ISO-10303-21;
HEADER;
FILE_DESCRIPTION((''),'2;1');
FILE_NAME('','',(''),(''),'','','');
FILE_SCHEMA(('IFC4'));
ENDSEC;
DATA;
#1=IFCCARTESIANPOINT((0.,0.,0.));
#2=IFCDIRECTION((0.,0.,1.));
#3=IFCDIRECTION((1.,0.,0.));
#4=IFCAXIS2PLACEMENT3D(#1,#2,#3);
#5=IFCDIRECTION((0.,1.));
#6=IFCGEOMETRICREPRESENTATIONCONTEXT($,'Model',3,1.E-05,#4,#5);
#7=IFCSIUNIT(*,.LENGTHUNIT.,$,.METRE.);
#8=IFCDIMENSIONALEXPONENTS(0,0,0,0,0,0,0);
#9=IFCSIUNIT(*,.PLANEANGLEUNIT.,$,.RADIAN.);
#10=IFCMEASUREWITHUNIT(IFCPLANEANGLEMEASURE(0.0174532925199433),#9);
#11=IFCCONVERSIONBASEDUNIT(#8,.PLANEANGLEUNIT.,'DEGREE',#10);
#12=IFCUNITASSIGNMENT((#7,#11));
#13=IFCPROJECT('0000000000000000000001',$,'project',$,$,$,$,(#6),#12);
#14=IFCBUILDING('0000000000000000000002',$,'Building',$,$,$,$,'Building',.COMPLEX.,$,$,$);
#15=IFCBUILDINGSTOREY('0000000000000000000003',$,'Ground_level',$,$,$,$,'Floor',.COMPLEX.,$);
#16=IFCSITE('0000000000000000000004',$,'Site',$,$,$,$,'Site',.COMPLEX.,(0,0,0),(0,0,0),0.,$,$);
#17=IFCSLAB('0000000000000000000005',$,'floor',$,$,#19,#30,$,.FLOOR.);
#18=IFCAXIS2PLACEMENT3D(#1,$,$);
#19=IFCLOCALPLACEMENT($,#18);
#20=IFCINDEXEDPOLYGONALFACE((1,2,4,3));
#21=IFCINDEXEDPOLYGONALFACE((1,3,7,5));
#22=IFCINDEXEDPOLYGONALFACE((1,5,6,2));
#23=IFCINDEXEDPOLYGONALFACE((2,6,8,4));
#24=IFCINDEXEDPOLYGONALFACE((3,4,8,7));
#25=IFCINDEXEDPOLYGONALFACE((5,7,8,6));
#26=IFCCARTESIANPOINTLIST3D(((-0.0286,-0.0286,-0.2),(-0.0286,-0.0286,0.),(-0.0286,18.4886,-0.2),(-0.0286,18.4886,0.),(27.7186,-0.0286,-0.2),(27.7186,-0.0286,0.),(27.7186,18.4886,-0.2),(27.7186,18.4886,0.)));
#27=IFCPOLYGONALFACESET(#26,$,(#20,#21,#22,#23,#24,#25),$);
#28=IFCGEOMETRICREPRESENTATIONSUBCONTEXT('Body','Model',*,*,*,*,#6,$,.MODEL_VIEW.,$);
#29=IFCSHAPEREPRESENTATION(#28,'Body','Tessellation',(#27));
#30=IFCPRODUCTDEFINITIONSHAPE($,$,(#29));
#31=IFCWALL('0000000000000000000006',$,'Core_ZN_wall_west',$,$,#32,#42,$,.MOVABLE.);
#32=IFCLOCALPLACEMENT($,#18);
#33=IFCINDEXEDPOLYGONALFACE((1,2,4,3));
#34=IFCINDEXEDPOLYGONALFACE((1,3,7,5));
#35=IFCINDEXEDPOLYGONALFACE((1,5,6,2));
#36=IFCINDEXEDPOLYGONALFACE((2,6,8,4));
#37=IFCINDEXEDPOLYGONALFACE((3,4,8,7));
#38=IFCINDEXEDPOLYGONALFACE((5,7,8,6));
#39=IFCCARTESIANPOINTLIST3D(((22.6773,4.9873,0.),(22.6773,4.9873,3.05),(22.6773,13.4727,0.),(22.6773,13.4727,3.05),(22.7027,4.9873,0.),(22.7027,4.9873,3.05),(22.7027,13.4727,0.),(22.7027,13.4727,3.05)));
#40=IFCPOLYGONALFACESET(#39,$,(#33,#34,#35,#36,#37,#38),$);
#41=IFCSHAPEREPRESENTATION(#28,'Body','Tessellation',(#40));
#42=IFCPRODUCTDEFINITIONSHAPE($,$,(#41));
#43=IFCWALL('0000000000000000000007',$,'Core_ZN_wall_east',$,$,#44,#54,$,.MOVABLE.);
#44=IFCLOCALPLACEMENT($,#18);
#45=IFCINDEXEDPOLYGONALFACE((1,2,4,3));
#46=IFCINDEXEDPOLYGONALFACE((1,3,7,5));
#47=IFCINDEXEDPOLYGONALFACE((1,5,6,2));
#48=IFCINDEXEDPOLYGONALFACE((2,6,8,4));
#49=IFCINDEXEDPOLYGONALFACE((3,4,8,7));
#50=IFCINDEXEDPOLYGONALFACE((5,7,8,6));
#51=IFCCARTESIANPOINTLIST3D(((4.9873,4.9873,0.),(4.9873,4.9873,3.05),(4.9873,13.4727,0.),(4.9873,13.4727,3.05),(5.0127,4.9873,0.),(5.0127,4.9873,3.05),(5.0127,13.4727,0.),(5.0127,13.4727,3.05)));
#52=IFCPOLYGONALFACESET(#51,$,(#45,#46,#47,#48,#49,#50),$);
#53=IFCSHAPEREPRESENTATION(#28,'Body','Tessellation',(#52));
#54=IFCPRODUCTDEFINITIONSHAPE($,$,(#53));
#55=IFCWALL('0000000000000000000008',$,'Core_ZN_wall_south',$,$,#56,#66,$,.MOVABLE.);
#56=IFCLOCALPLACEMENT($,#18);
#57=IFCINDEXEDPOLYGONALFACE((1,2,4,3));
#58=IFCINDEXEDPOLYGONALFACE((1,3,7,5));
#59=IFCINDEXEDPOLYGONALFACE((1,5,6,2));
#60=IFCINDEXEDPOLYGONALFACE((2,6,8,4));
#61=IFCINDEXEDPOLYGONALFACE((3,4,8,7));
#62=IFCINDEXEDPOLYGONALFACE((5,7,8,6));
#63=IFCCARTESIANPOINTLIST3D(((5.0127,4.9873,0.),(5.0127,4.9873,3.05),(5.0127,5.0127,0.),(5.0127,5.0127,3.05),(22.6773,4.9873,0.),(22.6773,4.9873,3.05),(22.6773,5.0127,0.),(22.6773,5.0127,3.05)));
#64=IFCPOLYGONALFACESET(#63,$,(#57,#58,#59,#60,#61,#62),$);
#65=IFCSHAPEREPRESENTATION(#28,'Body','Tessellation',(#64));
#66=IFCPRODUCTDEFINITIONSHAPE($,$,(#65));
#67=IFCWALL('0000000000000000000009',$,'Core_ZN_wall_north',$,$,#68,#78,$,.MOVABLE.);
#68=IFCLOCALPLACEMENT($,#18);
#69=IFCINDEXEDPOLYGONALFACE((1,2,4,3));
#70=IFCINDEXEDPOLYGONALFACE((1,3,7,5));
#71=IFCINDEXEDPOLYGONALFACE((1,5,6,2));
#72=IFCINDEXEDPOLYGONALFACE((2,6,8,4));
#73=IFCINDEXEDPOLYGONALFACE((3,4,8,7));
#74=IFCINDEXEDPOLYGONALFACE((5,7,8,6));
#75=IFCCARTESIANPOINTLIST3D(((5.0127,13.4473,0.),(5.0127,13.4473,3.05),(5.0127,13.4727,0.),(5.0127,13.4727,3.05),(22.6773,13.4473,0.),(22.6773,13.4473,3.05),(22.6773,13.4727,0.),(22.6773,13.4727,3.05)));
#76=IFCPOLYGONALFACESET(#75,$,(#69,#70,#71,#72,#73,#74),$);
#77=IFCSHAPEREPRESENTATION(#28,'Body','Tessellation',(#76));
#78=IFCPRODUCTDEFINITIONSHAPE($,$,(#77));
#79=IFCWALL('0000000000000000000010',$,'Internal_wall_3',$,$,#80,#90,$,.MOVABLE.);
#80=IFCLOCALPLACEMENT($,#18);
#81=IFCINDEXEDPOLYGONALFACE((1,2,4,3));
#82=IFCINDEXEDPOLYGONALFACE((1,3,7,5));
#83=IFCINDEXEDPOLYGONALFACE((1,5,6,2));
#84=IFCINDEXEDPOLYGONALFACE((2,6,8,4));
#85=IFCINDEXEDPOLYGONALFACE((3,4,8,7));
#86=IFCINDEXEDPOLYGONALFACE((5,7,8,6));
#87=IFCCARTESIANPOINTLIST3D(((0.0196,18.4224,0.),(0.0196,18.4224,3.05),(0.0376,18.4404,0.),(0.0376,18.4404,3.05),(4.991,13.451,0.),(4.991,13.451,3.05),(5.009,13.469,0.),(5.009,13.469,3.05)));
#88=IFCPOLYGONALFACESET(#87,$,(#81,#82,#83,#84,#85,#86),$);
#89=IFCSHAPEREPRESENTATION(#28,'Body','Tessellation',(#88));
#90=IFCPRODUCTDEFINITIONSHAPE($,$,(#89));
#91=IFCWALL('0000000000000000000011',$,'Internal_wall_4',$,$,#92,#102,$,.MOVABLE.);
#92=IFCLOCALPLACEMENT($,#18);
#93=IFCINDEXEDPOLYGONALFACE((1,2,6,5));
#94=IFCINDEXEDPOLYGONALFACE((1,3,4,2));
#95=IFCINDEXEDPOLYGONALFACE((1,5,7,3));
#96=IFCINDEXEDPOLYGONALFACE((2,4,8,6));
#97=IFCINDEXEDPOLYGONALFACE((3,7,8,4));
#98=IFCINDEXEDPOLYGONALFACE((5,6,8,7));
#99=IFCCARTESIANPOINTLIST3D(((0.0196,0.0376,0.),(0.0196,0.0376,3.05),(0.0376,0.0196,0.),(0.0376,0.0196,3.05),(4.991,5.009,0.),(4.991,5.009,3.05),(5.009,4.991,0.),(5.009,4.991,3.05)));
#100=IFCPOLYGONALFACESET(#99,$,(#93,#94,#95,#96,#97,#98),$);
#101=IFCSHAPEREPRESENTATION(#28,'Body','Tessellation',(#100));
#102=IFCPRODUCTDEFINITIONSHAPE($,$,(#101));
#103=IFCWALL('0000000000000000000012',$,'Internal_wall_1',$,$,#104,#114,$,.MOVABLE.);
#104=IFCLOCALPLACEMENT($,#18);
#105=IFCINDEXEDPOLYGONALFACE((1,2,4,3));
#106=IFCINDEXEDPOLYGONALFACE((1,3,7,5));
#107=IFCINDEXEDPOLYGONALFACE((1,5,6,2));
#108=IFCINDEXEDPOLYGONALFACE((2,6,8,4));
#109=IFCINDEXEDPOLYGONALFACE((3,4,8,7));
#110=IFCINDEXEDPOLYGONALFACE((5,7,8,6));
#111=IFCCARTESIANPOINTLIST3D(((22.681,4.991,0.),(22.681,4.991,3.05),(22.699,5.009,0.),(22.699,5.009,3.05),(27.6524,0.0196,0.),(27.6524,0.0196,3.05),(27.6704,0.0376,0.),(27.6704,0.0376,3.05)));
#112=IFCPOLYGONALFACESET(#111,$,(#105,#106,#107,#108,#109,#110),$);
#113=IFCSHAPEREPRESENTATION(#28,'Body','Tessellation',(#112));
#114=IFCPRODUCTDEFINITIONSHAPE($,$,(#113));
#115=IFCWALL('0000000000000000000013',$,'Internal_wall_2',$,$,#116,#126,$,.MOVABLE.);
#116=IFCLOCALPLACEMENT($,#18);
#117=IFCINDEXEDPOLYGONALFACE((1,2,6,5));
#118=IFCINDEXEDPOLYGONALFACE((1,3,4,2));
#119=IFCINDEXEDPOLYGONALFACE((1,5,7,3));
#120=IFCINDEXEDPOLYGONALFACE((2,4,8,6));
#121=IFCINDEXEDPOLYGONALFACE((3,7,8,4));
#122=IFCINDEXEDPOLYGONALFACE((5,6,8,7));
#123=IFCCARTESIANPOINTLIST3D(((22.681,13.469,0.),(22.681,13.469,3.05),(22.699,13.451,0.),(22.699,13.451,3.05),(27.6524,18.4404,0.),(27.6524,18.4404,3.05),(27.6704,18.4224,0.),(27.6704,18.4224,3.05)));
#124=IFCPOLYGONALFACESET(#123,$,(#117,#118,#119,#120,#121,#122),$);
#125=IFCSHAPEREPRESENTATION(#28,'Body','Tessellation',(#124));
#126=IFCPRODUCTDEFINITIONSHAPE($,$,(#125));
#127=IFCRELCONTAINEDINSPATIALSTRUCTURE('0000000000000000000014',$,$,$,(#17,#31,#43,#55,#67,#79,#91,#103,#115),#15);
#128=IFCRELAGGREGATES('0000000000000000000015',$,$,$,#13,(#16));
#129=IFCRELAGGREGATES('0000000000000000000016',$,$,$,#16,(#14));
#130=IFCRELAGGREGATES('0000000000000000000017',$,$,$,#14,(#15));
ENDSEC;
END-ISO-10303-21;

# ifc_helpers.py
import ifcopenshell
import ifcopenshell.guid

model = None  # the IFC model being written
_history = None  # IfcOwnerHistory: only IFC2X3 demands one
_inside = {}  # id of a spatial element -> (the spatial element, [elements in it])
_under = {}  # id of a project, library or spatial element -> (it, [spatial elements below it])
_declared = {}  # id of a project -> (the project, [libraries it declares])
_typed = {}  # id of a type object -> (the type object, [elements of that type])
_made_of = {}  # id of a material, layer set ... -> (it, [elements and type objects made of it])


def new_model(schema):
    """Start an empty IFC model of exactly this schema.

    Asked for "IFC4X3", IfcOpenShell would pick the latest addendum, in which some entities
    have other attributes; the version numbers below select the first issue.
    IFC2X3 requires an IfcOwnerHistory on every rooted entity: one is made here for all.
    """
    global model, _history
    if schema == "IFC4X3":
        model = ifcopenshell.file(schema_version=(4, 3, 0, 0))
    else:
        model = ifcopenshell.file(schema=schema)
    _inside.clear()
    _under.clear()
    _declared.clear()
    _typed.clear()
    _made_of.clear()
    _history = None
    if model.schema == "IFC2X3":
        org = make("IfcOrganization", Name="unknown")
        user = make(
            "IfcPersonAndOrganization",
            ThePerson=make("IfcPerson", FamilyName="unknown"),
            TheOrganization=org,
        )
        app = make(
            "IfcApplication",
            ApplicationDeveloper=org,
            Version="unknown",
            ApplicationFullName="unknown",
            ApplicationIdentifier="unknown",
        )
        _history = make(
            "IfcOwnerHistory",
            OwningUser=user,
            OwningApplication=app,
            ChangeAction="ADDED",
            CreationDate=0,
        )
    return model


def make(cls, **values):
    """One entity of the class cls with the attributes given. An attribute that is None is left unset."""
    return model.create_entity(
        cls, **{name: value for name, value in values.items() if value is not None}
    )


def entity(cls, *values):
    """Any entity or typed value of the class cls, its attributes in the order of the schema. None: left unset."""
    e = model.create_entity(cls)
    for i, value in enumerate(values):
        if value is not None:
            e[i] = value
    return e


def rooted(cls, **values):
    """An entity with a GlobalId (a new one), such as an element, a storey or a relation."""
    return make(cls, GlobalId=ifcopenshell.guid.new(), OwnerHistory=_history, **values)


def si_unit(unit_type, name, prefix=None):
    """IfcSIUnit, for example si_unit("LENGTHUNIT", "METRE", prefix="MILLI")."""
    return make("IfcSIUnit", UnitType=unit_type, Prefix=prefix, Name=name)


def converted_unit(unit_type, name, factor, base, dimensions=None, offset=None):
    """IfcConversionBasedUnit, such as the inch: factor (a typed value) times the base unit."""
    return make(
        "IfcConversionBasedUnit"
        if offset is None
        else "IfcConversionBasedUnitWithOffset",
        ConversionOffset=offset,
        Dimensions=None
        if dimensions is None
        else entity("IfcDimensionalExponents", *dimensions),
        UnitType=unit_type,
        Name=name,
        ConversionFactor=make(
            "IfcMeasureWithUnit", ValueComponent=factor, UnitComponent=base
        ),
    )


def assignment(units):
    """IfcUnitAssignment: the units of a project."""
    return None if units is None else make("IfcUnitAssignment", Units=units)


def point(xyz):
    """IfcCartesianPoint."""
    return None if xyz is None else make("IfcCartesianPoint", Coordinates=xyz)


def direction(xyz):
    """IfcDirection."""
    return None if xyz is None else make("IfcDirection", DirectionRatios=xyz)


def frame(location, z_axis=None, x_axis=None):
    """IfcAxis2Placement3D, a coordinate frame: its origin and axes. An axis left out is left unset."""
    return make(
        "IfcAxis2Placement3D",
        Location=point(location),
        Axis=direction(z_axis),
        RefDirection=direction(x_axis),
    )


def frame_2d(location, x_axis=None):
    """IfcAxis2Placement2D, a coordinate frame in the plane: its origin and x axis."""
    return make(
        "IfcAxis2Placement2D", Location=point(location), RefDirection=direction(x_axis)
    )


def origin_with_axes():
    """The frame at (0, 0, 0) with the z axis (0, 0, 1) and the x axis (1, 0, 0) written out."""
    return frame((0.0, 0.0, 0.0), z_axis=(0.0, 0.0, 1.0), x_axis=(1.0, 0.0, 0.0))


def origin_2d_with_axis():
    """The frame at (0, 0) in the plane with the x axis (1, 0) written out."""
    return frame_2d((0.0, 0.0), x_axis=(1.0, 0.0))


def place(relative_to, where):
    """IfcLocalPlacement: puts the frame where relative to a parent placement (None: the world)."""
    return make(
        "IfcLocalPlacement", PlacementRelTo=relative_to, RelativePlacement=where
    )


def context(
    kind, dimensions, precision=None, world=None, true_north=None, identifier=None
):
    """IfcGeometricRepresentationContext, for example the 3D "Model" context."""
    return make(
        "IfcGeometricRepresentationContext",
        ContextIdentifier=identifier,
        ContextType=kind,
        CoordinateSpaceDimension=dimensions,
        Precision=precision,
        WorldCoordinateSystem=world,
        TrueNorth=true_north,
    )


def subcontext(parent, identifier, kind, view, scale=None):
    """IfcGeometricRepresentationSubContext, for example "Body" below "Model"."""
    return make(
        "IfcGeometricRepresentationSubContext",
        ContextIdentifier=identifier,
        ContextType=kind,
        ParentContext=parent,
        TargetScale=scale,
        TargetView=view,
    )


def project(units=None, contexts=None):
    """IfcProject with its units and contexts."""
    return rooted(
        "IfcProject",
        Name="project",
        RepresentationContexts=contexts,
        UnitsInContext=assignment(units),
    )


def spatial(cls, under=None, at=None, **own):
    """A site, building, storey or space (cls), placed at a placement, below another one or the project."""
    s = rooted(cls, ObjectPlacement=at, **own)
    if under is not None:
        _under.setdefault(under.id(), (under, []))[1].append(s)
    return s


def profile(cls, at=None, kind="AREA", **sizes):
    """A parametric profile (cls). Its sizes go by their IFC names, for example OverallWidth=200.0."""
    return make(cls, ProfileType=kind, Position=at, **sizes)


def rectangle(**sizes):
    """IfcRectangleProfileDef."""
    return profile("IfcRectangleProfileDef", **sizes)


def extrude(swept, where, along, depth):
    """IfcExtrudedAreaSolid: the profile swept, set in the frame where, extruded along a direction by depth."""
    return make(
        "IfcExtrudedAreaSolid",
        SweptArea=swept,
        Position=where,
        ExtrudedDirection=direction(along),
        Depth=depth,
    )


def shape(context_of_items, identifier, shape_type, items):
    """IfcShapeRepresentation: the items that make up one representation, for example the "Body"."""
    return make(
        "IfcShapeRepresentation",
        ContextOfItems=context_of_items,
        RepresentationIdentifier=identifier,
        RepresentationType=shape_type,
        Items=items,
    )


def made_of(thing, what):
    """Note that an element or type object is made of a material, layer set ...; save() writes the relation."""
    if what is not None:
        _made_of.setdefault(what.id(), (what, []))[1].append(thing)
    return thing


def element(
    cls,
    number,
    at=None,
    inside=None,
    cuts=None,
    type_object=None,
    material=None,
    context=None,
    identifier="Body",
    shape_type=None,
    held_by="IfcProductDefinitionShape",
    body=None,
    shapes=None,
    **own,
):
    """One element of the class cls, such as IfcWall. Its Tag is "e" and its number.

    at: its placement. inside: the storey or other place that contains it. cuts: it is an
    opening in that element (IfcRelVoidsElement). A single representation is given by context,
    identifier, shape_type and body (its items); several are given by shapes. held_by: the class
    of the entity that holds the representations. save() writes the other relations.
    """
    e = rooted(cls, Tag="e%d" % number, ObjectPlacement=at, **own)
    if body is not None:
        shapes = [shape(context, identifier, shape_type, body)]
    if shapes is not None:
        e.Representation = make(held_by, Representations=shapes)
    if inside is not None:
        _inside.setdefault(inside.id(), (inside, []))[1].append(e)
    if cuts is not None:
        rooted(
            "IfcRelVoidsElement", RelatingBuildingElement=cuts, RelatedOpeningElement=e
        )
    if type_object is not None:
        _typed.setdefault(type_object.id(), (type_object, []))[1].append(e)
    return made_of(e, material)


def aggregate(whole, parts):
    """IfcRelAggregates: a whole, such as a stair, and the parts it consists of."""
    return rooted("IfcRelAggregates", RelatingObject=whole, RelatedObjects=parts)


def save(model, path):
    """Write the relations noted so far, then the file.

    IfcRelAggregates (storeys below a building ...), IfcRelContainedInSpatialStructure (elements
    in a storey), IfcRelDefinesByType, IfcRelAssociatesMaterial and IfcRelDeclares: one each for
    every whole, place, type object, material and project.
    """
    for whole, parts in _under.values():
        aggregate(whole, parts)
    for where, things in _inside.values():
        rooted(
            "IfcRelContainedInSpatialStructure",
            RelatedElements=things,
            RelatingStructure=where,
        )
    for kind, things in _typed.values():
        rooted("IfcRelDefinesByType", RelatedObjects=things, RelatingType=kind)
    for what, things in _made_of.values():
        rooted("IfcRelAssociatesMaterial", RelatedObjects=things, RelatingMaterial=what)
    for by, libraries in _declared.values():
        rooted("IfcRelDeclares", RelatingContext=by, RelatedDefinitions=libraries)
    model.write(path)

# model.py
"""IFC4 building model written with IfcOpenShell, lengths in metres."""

from ifc_helpers import new_model, entity, si_unit, converted_unit, direction, frame, frame_2d, origin_with_axes, origin_2d_with_axis, place, context, subcontext, project, spatial, rectangle, extrude, element, save


model = new_model("IFC4")

# Units and contexts
model_context = context("Model", 3, precision=1e-05, world=origin_with_axes(), true_north=direction((0.0, 1.0)))
body_context = subcontext(model_context, "Body", "Model", "MODEL_VIEW")
ifc_project = project(units=[si_unit("LENGTHUNIT", "METRE"), converted_unit("PLANEANGLEUNIT", "DEGREE", entity("IfcPlaneAngleMeasure", 0.0174532925199433), si_unit("PLANEANGLEUNIT", "RADIAN"), dimensions=[0, 0, 0, 0, 0, 0, 0])], contexts=[model_context])

# Site, building, storey
site = spatial("IfcSite", under=ifc_project, Name="Site", LongName="Site", CompositionType="COMPLEX", RefLatitude=(0, 0, 0), RefLongitude=(0, 0, 0), RefElevation=0.0)
building = spatial("IfcBuilding", under=site, Name="Building", LongName="Building", CompositionType="COMPLEX")
storey = spatial("IfcBuildingStorey", under=building, Name="Ground_level", LongName="Floor", CompositionType="COMPLEX")

# Slab
placement = place(None, origin_with_axes())
element("IfcSlab", 1, at=placement, inside=storey, Name="floor", PredefinedType="FLOOR", context=body_context, shape_type="SweptSolid", body=[
    extrude(rectangle(XDim=27.7472, YDim=18.5172, at=frame_2d((0.0, 0.0), x_axis=(-1.0, 0.0))), frame((13.845, 9.23, 0.0), z_axis=(0.0, 0.0, 1.0), x_axis=(1.0, 0.0, 0.0)), (0.0, 0.0, -1.0), 0.2),
])

# Walls
element("IfcWall", 2, at=placement, inside=storey, Name="Core_ZN_wall_west", PredefinedType="MOVABLE", context=body_context, shape_type="SweptSolid", body=[
    extrude(rectangle(XDim=8.4854, YDim=0.0254, at=frame_2d((0.0, 0.0), x_axis=(0.0, 1.0))), frame((22.69, 9.23, 0.0), z_axis=(0.0, 0.0, 1.0), x_axis=(1.0, 0.0, 0.0)), (0.0, 0.0, 1.0), 3.05),
])
element("IfcWall", 3, at=placement, inside=storey, Name="Core_ZN_wall_east", PredefinedType="MOVABLE", context=body_context, shape_type="SweptSolid", body=[
    extrude(rectangle(XDim=8.4854, YDim=0.0254, at=frame_2d((0.0, 0.0), x_axis=(0.0, 1.0))), frame((5.0, 9.23, 0.0), z_axis=(0.0, 0.0, 1.0), x_axis=(1.0, 0.0, 0.0)), (0.0, 0.0, 1.0), 3.05),
])
element("IfcWall", 4, at=placement, inside=storey, Name="Core_ZN_wall_south", PredefinedType="MOVABLE", context=body_context, shape_type="SweptSolid", body=[
    extrude(rectangle(XDim=17.6646, YDim=0.0254, at=origin_2d_with_axis()), frame((13.845, 5.0, 0.0), z_axis=(0.0, 0.0, 1.0), x_axis=(1.0, 0.0, 0.0)), (0.0, 0.0, 1.0), 3.05),
])
element("IfcWall", 5, at=placement, inside=storey, Name="Core_ZN_wall_north", PredefinedType="MOVABLE", context=body_context, shape_type="SweptSolid", body=[
    extrude(rectangle(XDim=17.6646, YDim=0.0254, at=frame_2d((0.0, 0.0), x_axis=(1.0, 0.0))), frame((13.845, 13.46, 0.0), z_axis=(0.0, 0.0, 1.0), x_axis=(1.0, 0.0, 0.0)), (0.0, 0.0, 1.0), 3.05),
])
element("IfcWall", 6, at=placement, inside=storey, Name="Internal_wall_3", PredefinedType="MOVABLE", context=body_context, shape_type="SweptSolid", body=[
    extrude(rectangle(XDim=7.0306, YDim=0.0254, at=frame_2d((0.0, 0.0), x_axis=(0.707107, -0.707107))), frame((2.5143, 15.9457, 0.0), z_axis=(0.0, 0.0, 1.0), x_axis=(1.0, 0.0, 0.0)), (0.0, 0.0, 1.0), 3.05),
])
element("IfcWall", 7, at=placement, inside=storey, Name="Internal_wall_4", PredefinedType="MOVABLE", context=body_context, shape_type="SweptSolid", body=[
    extrude(rectangle(XDim=7.0306, YDim=0.0254, at=frame_2d((0.0, 0.0), x_axis=(0.707107, 0.707107))), frame((2.5143, 2.5143, 0.0), z_axis=(0.0, 0.0, 1.0), x_axis=(1.0, 0.0, 0.0)), (0.0, 0.0, 1.0), 3.05),
])
element("IfcWall", 8, at=placement, inside=storey, Name="Internal_wall_1", PredefinedType="MOVABLE", context=body_context, shape_type="SweptSolid", body=[
    extrude(rectangle(XDim=7.0306, YDim=0.0254, at=frame_2d((0.0, 0.0), x_axis=(0.707107, -0.707107))), frame((25.1757, 2.5143, 0.0), z_axis=(0.0, 0.0, 1.0), x_axis=(1.0, 0.0, 0.0)), (0.0, 0.0, 1.0), 3.05),
])
element("IfcWall", 9, at=placement, inside=storey, Name="Internal_wall_2", PredefinedType="MOVABLE", context=body_context, shape_type="SweptSolid", body=[
    extrude(rectangle(XDim=7.0306, YDim=0.0254, at=frame_2d((0.0, 0.0), x_axis=(0.707107, 0.707107))), frame((25.1757, 15.9457, 0.0), z_axis=(0.0, 0.0, 1.0), x_axis=(1.0, 0.0, 0.0)), (0.0, 0.0, 1.0), 3.05),
])

save(model, "model.ifc")
